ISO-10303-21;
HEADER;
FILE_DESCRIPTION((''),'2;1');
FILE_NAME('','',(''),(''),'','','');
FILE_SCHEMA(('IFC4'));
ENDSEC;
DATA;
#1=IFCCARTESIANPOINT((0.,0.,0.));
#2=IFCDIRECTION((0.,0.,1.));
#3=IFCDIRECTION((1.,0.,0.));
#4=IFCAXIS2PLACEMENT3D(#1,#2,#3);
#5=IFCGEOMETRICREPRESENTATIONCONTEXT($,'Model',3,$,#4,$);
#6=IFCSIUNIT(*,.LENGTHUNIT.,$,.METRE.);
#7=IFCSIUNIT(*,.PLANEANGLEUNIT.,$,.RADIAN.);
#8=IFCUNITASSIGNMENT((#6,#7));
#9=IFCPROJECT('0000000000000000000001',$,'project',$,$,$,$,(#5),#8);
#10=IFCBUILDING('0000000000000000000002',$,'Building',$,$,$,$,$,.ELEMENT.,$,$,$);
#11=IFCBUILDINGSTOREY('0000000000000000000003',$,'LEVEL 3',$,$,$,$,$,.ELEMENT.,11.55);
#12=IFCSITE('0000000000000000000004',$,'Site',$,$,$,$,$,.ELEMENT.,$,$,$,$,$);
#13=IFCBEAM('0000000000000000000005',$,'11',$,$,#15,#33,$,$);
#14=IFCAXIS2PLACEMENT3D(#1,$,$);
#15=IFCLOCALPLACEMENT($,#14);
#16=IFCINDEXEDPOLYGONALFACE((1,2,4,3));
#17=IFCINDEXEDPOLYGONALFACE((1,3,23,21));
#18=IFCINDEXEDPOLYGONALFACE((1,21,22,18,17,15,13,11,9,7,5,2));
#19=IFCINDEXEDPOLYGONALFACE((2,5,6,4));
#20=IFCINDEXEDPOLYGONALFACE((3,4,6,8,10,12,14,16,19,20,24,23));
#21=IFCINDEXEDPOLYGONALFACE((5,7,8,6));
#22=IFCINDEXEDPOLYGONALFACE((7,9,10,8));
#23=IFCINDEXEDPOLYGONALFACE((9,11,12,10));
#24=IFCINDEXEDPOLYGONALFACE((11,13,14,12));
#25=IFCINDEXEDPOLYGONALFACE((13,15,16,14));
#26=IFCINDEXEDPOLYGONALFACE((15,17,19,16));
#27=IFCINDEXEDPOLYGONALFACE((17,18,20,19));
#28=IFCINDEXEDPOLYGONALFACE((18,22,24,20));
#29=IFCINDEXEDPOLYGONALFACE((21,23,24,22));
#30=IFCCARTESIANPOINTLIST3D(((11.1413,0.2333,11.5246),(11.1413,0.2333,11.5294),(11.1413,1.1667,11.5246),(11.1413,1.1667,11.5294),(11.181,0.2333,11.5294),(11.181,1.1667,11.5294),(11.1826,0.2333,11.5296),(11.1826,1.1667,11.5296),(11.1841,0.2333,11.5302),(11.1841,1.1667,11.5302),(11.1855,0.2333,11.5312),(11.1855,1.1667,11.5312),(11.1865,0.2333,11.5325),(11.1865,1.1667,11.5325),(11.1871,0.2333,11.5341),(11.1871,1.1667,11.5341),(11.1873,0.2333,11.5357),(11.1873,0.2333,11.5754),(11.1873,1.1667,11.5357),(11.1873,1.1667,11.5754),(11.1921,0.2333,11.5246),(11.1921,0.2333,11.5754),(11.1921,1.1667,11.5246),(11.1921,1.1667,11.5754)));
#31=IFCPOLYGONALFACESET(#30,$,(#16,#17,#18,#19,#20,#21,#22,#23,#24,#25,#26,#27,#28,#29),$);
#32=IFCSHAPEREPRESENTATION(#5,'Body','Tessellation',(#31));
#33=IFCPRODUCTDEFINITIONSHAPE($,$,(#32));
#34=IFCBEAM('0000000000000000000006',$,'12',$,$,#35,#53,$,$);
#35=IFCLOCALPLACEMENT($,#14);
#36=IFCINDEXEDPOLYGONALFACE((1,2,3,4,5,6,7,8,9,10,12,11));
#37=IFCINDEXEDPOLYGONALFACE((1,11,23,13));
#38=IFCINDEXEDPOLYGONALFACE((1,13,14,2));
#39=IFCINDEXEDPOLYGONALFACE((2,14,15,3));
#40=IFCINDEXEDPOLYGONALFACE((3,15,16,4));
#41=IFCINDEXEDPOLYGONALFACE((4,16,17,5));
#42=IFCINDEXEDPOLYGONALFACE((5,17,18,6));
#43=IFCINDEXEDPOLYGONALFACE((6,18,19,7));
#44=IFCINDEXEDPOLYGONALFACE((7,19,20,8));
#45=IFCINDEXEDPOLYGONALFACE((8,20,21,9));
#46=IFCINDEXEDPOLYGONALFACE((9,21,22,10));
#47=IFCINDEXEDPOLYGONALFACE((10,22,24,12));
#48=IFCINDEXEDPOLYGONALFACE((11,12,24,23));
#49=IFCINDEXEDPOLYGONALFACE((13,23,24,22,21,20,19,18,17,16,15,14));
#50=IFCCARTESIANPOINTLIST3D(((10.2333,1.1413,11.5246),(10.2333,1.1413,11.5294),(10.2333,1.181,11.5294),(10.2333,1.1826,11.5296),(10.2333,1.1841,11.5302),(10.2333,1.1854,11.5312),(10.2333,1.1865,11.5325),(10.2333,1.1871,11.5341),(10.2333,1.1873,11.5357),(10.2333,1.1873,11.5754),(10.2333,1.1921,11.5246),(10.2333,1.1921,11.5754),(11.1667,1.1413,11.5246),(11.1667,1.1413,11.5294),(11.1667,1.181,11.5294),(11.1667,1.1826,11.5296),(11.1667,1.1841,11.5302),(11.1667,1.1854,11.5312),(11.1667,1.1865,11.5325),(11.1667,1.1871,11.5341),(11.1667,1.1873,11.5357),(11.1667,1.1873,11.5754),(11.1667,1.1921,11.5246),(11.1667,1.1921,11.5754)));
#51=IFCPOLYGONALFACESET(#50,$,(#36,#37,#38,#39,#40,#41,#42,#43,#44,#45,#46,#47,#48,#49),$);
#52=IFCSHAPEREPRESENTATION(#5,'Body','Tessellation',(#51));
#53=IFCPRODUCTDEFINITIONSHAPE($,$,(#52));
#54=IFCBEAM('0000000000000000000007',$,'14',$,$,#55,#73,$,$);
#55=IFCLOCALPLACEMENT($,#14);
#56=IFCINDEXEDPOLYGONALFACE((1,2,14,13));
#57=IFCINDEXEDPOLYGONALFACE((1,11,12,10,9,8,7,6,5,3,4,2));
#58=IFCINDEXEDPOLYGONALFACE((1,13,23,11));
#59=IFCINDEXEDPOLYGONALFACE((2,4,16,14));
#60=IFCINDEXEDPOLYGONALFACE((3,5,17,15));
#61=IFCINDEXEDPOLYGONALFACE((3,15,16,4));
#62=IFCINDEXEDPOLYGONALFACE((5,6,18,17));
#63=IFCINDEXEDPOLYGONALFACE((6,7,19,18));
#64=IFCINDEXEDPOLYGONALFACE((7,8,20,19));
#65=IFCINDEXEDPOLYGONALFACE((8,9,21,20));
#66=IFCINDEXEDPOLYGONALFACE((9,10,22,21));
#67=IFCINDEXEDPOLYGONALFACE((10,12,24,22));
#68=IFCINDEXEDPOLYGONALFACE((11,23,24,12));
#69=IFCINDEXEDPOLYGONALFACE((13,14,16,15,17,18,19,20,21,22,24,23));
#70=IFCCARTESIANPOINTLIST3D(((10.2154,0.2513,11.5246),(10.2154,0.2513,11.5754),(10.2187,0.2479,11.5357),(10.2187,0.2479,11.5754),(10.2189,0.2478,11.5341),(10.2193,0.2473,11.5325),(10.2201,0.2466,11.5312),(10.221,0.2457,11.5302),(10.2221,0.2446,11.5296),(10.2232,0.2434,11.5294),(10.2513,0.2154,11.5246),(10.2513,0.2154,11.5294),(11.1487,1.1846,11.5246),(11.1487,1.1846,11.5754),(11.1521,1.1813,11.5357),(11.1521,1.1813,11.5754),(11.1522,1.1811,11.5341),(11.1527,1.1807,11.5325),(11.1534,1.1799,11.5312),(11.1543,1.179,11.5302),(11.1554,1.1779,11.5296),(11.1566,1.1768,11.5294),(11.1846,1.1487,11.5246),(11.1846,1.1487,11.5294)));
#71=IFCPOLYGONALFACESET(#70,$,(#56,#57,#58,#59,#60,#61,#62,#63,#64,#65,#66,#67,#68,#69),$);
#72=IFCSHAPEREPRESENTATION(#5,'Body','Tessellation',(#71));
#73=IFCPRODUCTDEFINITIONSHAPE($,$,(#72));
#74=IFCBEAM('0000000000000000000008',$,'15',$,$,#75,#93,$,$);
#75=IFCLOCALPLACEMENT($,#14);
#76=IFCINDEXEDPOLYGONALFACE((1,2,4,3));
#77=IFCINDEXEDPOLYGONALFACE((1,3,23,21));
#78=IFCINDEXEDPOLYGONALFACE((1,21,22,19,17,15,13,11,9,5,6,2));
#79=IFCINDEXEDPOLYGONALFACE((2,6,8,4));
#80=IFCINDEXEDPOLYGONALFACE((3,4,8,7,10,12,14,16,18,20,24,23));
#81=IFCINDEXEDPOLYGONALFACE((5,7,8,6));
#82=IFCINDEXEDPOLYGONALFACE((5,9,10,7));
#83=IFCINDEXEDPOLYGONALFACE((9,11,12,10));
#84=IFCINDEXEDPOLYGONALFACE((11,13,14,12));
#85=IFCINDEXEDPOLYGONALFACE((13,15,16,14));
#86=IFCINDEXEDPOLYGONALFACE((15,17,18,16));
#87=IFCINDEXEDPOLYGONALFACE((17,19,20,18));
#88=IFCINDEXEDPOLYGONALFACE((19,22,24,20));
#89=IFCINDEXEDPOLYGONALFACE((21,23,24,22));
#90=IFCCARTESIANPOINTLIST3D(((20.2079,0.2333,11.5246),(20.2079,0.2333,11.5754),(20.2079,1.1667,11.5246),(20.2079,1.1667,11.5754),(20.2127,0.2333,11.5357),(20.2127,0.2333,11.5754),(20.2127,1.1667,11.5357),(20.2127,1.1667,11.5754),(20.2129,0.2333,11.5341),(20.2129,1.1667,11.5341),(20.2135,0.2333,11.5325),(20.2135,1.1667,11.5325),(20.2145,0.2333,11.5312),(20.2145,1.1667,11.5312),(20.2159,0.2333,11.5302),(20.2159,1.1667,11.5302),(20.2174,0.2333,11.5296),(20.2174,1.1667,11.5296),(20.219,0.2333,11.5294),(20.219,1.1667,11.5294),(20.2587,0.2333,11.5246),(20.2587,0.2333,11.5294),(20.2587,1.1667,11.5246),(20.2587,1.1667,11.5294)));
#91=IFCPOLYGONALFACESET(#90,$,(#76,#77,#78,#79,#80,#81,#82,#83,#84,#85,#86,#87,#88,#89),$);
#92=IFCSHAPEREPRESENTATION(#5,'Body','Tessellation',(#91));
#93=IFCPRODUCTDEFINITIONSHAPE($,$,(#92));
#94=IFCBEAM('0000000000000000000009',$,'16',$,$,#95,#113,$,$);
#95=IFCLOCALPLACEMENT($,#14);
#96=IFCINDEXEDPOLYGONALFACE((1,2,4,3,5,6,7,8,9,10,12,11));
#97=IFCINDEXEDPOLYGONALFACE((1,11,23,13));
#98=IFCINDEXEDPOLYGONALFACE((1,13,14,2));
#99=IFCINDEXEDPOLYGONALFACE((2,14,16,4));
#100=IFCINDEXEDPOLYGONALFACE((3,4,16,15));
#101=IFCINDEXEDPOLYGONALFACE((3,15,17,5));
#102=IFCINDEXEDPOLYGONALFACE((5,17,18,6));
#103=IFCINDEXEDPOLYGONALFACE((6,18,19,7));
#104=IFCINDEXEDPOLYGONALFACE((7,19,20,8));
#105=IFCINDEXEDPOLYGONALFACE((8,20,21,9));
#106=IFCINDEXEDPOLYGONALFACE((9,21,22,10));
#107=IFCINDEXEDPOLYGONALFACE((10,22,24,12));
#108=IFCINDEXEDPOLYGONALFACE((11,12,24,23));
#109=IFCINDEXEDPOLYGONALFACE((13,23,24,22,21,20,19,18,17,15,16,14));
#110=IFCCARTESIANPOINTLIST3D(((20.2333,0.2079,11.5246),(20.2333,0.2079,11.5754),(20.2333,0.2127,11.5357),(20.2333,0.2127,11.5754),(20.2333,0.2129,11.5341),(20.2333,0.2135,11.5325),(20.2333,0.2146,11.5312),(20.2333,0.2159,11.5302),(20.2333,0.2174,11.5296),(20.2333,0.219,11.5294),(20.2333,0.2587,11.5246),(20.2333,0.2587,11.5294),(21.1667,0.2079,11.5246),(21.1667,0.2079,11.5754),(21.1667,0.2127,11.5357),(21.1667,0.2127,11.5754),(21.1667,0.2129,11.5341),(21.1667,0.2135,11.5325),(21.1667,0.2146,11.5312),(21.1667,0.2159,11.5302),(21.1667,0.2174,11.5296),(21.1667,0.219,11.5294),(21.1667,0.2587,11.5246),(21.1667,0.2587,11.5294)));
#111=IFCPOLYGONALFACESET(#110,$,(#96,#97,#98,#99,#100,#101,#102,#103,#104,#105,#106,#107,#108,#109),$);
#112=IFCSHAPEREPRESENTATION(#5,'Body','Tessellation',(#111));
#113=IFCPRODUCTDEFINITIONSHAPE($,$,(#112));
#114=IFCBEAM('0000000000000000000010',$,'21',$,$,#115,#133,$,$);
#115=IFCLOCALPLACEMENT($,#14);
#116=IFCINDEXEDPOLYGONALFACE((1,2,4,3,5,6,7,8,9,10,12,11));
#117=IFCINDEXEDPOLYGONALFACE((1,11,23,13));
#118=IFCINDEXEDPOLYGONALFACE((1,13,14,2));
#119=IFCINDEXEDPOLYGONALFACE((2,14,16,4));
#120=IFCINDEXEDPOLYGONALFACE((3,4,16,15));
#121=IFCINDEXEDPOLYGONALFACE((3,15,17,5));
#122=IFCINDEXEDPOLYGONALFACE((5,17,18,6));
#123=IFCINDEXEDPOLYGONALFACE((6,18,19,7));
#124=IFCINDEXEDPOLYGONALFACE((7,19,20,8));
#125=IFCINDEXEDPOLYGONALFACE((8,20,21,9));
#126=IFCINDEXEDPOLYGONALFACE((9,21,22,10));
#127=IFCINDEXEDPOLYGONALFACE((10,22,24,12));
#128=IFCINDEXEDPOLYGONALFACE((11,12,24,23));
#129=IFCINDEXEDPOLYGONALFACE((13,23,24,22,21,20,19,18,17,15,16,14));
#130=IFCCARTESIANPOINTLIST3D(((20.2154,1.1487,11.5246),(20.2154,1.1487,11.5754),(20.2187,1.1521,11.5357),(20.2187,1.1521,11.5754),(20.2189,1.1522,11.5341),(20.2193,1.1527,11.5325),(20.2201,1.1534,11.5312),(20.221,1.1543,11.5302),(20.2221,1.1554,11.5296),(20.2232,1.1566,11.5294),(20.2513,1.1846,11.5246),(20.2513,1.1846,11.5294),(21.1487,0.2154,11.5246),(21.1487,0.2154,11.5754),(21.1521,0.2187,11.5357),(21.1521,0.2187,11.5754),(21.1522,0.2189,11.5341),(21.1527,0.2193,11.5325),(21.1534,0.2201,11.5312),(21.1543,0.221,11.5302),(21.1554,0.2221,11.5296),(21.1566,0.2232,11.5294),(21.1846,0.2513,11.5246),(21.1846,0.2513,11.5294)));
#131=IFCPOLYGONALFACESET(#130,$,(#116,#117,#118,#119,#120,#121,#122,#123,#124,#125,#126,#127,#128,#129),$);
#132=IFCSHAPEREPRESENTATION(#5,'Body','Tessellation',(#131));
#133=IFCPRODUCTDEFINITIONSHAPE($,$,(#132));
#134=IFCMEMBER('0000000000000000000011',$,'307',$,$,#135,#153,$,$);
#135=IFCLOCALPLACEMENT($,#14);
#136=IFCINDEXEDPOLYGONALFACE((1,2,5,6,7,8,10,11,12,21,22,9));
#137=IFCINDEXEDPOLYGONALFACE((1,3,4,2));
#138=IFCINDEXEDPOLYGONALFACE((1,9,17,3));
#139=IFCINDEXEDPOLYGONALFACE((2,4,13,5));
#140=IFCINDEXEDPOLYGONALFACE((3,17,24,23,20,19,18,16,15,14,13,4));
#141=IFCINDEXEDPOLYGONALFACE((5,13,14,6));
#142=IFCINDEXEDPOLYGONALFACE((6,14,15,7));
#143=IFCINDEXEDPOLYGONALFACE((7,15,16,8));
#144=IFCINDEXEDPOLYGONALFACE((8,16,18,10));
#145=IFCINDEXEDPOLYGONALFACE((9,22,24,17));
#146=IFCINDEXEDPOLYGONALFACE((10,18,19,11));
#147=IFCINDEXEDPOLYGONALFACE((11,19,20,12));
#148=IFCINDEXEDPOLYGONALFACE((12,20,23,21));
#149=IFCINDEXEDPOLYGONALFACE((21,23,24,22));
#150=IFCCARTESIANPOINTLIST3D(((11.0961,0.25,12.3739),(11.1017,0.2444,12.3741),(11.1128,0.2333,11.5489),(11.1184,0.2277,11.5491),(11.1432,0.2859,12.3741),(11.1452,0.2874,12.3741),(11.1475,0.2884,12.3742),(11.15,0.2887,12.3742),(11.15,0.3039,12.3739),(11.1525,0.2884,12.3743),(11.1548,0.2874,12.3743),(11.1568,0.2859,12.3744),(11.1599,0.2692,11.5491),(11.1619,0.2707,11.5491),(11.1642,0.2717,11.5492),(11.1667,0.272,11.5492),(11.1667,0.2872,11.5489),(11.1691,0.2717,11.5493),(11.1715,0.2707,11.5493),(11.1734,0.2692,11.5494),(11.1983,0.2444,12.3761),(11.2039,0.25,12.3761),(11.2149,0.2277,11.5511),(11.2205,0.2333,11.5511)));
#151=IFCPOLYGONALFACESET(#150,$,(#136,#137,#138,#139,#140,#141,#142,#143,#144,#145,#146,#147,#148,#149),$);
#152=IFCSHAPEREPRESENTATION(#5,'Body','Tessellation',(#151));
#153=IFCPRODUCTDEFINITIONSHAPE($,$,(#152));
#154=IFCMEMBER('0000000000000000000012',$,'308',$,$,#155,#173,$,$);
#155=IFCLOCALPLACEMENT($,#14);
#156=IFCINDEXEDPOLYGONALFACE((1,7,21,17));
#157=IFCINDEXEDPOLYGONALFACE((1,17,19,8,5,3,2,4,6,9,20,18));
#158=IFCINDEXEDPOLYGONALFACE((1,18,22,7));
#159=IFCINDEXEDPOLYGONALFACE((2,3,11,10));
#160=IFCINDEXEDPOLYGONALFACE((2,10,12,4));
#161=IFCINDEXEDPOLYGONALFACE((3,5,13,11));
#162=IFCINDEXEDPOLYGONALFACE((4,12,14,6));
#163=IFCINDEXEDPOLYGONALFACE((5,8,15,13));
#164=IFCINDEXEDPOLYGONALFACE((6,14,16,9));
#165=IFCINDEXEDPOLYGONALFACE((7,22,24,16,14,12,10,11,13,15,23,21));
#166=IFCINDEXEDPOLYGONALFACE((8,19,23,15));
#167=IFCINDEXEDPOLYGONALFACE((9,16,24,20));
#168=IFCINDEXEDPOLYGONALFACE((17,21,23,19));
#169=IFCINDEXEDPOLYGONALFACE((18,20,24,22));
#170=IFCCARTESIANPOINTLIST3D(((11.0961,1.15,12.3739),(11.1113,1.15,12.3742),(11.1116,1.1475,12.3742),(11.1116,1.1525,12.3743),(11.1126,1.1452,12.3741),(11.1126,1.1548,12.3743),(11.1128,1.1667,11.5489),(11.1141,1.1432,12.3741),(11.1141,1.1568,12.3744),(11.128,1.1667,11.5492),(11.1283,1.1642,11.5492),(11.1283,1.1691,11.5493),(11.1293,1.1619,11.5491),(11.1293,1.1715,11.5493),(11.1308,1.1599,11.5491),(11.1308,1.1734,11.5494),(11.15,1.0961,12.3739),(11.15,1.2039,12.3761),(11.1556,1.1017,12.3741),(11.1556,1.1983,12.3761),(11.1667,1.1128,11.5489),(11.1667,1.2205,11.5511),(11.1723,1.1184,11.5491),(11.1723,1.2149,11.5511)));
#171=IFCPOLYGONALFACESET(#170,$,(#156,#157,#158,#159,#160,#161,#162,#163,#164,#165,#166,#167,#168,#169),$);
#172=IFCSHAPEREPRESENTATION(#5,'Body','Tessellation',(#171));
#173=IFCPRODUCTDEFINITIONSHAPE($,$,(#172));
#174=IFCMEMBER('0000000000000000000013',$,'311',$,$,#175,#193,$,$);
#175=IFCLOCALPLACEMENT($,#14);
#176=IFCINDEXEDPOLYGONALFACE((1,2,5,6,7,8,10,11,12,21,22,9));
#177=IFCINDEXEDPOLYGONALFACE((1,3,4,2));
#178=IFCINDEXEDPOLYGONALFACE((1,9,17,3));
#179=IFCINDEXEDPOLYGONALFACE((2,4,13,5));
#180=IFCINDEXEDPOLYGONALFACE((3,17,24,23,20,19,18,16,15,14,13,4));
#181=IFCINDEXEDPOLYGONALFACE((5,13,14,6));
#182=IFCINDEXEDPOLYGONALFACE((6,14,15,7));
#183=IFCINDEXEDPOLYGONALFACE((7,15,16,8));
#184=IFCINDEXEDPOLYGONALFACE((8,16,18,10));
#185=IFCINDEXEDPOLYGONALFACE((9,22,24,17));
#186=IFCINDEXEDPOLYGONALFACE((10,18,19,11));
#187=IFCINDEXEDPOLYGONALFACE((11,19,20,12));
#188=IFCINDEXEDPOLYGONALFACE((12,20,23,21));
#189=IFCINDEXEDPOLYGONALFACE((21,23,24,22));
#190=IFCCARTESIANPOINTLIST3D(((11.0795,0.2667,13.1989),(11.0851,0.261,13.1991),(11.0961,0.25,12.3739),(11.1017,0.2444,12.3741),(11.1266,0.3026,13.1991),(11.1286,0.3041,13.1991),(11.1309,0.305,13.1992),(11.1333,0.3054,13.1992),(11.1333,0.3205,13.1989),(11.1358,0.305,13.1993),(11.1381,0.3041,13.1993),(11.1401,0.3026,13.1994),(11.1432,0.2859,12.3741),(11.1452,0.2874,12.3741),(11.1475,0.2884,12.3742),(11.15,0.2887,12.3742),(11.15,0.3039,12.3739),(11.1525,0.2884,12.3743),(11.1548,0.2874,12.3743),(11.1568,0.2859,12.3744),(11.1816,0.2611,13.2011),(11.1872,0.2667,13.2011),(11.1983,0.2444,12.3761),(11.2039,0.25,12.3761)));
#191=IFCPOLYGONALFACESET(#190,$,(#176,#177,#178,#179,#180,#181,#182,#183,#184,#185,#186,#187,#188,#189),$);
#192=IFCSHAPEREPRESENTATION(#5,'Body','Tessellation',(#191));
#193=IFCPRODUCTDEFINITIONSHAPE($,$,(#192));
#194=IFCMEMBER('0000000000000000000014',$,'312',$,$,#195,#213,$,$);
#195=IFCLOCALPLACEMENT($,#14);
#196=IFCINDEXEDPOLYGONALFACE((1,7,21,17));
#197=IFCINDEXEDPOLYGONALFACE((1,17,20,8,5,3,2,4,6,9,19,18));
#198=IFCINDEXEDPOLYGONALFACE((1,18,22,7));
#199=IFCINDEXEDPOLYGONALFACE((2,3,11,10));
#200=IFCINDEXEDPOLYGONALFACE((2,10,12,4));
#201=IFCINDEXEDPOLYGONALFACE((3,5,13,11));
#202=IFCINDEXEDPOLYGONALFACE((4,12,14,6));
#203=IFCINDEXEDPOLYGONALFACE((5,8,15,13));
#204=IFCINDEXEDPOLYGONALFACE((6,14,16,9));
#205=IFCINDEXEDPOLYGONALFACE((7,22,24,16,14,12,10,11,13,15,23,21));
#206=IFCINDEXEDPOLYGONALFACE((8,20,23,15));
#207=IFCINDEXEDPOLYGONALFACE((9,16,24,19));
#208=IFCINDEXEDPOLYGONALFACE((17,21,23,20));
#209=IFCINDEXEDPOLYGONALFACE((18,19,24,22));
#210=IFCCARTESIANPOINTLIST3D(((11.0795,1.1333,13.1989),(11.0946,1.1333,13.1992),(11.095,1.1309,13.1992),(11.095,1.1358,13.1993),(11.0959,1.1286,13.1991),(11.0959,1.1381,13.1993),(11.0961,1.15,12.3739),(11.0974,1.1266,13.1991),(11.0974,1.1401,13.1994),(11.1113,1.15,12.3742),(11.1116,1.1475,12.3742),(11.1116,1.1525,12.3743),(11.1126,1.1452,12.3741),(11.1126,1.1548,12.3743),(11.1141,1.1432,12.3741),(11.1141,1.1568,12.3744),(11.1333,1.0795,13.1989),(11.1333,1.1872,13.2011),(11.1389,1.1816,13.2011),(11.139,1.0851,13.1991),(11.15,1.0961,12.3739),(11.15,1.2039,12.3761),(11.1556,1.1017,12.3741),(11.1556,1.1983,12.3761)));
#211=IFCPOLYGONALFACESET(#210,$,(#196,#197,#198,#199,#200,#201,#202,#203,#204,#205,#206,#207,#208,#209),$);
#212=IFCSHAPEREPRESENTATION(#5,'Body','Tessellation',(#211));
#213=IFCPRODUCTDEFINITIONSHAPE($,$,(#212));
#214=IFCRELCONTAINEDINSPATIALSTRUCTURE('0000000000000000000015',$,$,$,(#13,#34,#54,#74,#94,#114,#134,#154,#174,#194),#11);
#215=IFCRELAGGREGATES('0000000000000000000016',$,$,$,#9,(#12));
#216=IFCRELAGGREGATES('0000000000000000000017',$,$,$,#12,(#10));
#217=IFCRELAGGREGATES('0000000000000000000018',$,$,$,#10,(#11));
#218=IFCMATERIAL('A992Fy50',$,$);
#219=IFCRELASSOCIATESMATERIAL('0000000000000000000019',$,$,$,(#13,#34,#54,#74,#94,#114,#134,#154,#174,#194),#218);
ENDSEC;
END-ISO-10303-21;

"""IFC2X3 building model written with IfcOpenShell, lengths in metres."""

from ifc_helpers import new_model, si_unit, frame, origin_with_axes, origin_2d_with_axis, place, context, project, spatial, l_section, extrude, material, element, save


model = new_model("IFC2X3")

# Units and contexts
model_context = context("Model", 3, world=origin_with_axes())
ifc_project = project(units=[si_unit("LENGTHUNIT", "METRE"), si_unit("PLANEANGLEUNIT", "RADIAN")], contexts=[model_context])

# Site, building, storey
site = spatial("IfcSite", under=ifc_project, Name="Site", CompositionType="ELEMENT")
building = spatial("IfcBuilding", under=site, Name="Building", CompositionType="ELEMENT")
storey = spatial("IfcBuildingStorey", under=building, Name="LEVEL 3", CompositionType="ELEMENT", Elevation=11.55)

# Beams
ifc_material = material(Name="A992Fy50")
for number, where, z_axis, x_axis, name in (
    (1, (11.1667, 0.2333, 11.55), (0.0, 1.0, 0.0), (-1.0, 0.0, 0.0), "11"),
    (2, (11.1667, 1.1667, 11.55), (-1.0, 0.0, 0.0), (0.0, -1.0, 0.0), "12"),
):
    element("IfcBeam", number, at=place(None, frame(where, z_axis=z_axis, x_axis=x_axis)), inside=storey, material=ifc_material, Name=name, context=model_context, shape_type="SweptSolid", body=[
        extrude(l_section(Depth=0.0508, Width=0.0508, Thickness=0.0048, FilletRadius=0.0063, at=origin_2d_with_axis()), origin_with_axes(), (0.0, 0.0, 1.0), 0.9333),
    ])
beam_1_placement = place(None, frame((11.1667, 1.1667, 11.55), z_axis=(-0.707107, -0.707107, 0.0), x_axis=(0.707107, -0.707107, 0.0)))
element("IfcBeam", 3, at=beam_1_placement, inside=storey, material=ifc_material, Name="14", context=model_context, shape_type="SweptSolid", body=[
    extrude(l_section(Depth=0.0508, Width=0.0508, Thickness=0.0048, FilletRadius=0.0063, at=origin_2d_with_axis()), origin_with_axes(), (0.0, 0.0, 1.0), 1.3199),
])
for number, where, z_axis, x_axis, name in (
    (4, (20.2333, 1.1667, 11.55), (0.0, -1.0, 0.0), (1.0, 0.0, 0.0), "15"),
    (5, (20.2333, 0.2333, 11.55), (1.0, 0.0, 0.0), (0.0, 1.0, 0.0), "16"),
):
    element("IfcBeam", number, at=place(None, frame(where, z_axis=z_axis, x_axis=x_axis)), inside=storey, material=ifc_material, Name=name, context=model_context, shape_type="SweptSolid", body=[
        extrude(l_section(Depth=0.0508, Width=0.0508, Thickness=0.0048, FilletRadius=0.0063, at=origin_2d_with_axis()), origin_with_axes(), (0.0, 0.0, 1.0), 0.9333),
    ])
beam_2_placement = place(None, frame((20.2333, 1.1667, 11.55), z_axis=(0.707107, -0.707107, 0.0), x_axis=(0.707107, 0.707107, 0.0)))
element("IfcBeam", 6, at=beam_2_placement, inside=storey, material=ifc_material, Name="21", context=model_context, shape_type="SweptSolid", body=[
    extrude(l_section(Depth=0.0508, Width=0.0508, Thickness=0.0048, FilletRadius=0.0063, at=origin_2d_with_axis()), origin_with_axes(), (0.0, 0.0, 1.0), 1.3199),
])

# Members
for number, where, z_axis, x_axis, name in (
    (7, (11.1667, 0.2333, 11.55), (-0.020194, 0.020194, 0.999592), (-0.707107, -0.707107, 0.0), "307"),
    (8, (11.1667, 1.1667, 11.55), (-0.020194, -0.020194, 0.999592), (0.707107, -0.707107, 0.0), "308"),
    (9, (11.15, 0.25, 12.375), (-0.020194, 0.020194, 0.999592), (-0.707107, -0.707107, 0.0), "311"),
    (10, (11.15, 1.15, 12.375), (-0.020194, -0.020194, 0.999592), (0.707107, -0.707107, 0.0), "312"),
):
    element("IfcMember", number, at=place(None, frame(where, z_axis=z_axis, x_axis=x_axis)), inside=storey, material=ifc_material, Name=name, context=model_context, shape_type="SweptSolid", body=[
        extrude(l_section(Depth=0.0762, Width=0.0762, Thickness=0.0079, FilletRadius=0.0096, at=origin_2d_with_axis()), origin_with_axes(), (0.0, 0.0, 1.0), 0.8253),
    ])

save(model, "model.ifc")
